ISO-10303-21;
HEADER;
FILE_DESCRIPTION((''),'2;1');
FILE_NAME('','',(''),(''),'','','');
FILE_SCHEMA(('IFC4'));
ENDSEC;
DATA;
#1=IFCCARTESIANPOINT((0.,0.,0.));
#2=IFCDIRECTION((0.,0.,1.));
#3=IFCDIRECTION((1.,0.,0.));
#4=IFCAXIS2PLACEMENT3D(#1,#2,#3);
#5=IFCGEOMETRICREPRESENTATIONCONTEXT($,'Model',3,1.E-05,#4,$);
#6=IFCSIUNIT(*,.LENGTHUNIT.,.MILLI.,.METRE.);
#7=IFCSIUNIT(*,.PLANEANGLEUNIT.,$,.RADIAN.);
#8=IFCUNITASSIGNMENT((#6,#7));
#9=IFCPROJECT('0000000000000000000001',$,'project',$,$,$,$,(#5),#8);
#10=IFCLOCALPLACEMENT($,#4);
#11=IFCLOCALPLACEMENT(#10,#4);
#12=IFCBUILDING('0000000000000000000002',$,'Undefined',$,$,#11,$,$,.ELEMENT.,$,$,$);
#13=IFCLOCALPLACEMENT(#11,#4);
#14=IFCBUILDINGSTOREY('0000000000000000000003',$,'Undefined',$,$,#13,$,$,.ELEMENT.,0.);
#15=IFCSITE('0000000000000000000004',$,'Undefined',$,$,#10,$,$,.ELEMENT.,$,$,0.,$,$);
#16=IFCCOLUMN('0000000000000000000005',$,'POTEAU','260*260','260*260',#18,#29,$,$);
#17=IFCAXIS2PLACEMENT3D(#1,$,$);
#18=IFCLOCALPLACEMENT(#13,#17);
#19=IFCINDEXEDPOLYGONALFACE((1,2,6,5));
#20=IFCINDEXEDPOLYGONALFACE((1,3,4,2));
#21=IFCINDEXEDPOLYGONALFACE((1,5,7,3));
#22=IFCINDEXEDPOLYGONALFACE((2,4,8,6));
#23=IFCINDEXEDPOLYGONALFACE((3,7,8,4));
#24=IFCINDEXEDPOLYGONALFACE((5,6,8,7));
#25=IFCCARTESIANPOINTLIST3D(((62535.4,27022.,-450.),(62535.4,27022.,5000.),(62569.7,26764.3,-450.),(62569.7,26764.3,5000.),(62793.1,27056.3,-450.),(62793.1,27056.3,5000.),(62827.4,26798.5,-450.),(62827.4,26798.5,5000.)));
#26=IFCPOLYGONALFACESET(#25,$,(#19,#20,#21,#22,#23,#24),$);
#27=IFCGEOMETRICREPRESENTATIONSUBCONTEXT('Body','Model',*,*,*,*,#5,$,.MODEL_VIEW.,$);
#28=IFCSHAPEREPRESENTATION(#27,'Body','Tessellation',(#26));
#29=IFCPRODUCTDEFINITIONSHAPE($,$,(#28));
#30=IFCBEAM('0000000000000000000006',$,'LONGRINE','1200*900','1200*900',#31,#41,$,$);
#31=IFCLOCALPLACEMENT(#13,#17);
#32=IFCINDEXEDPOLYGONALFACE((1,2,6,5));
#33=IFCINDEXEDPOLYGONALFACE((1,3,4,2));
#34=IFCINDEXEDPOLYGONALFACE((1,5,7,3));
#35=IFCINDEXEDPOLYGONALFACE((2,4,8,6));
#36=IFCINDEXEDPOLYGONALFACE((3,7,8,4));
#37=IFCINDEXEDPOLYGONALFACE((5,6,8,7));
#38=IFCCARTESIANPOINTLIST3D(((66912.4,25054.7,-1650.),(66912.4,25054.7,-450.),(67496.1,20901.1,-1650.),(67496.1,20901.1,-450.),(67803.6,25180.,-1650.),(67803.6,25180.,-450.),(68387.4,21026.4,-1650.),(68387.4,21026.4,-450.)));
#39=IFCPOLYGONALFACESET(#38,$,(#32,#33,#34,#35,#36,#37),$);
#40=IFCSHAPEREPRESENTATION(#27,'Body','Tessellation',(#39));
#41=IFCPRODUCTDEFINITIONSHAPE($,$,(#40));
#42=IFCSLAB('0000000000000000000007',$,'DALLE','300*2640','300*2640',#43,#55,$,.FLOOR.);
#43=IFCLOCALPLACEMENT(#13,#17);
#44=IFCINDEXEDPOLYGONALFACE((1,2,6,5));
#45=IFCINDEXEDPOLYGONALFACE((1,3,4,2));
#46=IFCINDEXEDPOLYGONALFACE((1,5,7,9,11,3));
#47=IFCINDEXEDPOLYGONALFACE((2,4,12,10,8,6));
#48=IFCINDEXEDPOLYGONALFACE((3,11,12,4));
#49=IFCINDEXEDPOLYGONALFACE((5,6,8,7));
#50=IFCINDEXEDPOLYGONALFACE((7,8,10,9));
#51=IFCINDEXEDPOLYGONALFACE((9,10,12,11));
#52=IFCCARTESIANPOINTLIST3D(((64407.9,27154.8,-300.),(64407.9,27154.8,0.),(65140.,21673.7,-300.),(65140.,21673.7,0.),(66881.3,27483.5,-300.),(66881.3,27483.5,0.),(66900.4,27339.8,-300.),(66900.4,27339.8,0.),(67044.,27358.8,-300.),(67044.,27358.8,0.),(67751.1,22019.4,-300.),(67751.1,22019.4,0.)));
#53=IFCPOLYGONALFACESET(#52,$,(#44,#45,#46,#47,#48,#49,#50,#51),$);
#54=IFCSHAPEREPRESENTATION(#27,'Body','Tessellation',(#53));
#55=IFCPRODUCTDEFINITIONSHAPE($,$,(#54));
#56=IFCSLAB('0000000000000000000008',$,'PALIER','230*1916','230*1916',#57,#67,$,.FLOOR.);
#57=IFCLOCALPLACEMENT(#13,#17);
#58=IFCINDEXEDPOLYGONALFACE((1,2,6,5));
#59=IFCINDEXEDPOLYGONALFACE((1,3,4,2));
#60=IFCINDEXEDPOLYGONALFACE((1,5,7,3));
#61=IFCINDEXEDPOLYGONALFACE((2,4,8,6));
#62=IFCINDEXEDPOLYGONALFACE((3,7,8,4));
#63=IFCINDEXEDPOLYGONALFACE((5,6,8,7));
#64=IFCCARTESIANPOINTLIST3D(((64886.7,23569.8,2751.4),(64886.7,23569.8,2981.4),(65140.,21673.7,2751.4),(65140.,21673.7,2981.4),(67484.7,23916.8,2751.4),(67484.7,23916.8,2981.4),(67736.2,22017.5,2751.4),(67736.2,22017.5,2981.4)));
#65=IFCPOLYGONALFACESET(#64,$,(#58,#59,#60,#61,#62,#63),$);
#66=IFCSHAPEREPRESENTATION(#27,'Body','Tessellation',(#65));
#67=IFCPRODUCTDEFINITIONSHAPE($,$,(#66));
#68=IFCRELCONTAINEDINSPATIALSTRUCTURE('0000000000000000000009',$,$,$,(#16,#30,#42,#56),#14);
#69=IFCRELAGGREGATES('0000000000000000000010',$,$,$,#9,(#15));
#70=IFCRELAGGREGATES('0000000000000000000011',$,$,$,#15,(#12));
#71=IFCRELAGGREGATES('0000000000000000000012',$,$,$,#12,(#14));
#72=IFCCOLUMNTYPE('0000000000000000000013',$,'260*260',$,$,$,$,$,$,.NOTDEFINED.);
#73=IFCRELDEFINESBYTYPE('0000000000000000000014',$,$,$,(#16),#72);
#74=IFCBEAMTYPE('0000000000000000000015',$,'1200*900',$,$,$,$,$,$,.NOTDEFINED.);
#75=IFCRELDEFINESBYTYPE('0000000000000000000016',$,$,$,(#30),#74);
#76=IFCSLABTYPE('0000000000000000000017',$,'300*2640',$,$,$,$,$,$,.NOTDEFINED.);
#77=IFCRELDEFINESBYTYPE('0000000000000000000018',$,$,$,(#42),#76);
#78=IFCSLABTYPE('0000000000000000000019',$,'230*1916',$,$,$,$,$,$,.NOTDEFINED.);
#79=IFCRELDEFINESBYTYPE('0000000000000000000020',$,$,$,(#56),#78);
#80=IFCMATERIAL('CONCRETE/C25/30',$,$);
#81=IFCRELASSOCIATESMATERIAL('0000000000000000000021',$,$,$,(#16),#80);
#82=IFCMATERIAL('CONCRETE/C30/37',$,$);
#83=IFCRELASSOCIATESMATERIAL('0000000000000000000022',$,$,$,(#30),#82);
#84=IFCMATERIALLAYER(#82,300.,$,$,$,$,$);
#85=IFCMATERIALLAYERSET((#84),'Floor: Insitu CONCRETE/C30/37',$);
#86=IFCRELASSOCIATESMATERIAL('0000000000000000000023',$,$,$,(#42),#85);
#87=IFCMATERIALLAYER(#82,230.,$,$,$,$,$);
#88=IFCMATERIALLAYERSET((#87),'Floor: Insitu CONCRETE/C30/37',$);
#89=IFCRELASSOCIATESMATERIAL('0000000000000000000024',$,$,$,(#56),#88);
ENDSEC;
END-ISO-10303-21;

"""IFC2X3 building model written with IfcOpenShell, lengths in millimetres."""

from ifc_helpers import new_model, si_unit, frame, origin_with_axes, origin_2d_with_axis, place, context, subcontext, project, spatial, polyline, rectangle, outline, extrude, material, layer, layer_set, layer_usage, type_object, element, save


model = new_model("IFC2X3")

# Units and contexts
model_context = context("Model", 3, precision=1e-05, world=origin_with_axes())
body_context = subcontext(model_context, "Body", "Model", "MODEL_VIEW")
ifc_project = project(units=[si_unit("LENGTHUNIT", "METRE", prefix="MILLI"), si_unit("PLANEANGLEUNIT", "RADIAN")], contexts=[model_context])

# Site, building, storey
site_placement = place(None, origin_with_axes())
site = spatial("IfcSite", under=ifc_project, at=site_placement, Name="Undefined", CompositionType="ELEMENT", RefElevation=0.0)
building_placement = place(site_placement, origin_with_axes())
building = spatial("IfcBuilding", under=site, at=building_placement, Name="Undefined", CompositionType="ELEMENT")
storey_placement = place(building_placement, origin_with_axes())
storey = spatial("IfcBuildingStorey", under=building, at=storey_placement, Name="Undefined", CompositionType="ELEMENT", Elevation=0.0)

# Column
ifc_material_1 = material(Name="CONCRETE/C30/37")
ifc_material_2 = material(Name="CONCRETE/C25/30")
column_type_1 = type_object("IfcColumnType", Name="260*260", PredefinedType="NOTDEFINED")
column_1_placement = place(storey_placement, frame((62681.4, 26910.3, -450.0), z_axis=(0.0, 0.0, 1.0), x_axis=(1.0, 0.0, 0.0)))
element("IfcColumn", 1, at=column_1_placement, inside=storey, type_object=column_type_1, material=ifc_material_2, Name="POTEAU", Description="260*260", ObjectType="260*260", context=body_context, shape_type="SweptSolid", body=[
    extrude(rectangle(XDim=260.0, YDim=260.0, at=origin_2d_with_axis()), frame((0.0, 0.0, 5450.0), z_axis=(0.0, 0.0, -1.0), x_axis=(-0.131727, 0.991286, 0.0)), (0.0, 0.0, 1.0), 5450.0),
])

# Beam
beam_type_1 = type_object("IfcBeamType", Name="1200*900", PredefinedType="NOTDEFINED")
beam_1_placement = place(storey_placement, frame((67941.7, 20963.8, -1050.0), z_axis=(0.0, 0.0, 1.0), x_axis=(-0.139174, 0.990268, 0.0)))
element("IfcBeam", 2, at=beam_1_placement, inside=storey, type_object=beam_type_1, material=ifc_material_1, Name="LONGRINE", Description="1200*900", ObjectType="1200*900", context=body_context, shape_type="SweptSolid", body=[
    extrude(rectangle(XDim=900.0, YDim=1200.0, at=origin_2d_with_axis()), frame((4194.4, 0.0, 0.0), z_axis=(-1.0, 0.0, 0.0), x_axis=(0.0, -1.0, 0.0)), (0.0, 0.0, 1.0), 4194.4),
])

# Slabs
ifc_layer_1 = layer(ifc_material_1, 300.0)
ifc_layer_set_1 = layer_set([ifc_layer_1], Name="Floor: Insitu CONCRETE/C30/37")
ifc_layer_usage_1 = layer_usage(ifc_layer_set_1, "AXIS3", "POSITIVE", -150.0)
slab_type_1 = type_object("IfcSlabType", Name="300*2640", PredefinedType="NOTDEFINED")
slab_1_placement = place(storey_placement, frame((67751.1, 22019.4, -150.0), z_axis=(0.0, 0.0, -1.0), x_axis=(-0.991345, -0.131283, 0.0)))
element("IfcSlab", 3, at=slab_1_placement, inside=storey, type_object=slab_type_1, material=ifc_layer_usage_1, Name="DALLE", Description="300*2640", ObjectType="300*2640", PredefinedType="FLOOR", context=body_context, shape_type="SweptSolid", body=[
    extrude(outline(polyline([(0.0, 0.0), (2633.9, 0.0), (2640.1, 5529.8), (144.9, 5531.0), (144.9, 5386.0), (0.0, 5386.0), (0.0, 0.0)])), frame((0.0, 0.0, -150.0), z_axis=(0.0, 0.0, 1.0), x_axis=(1.0, 0.0, 0.0)), (0.0, 0.0, 1.0), 300.0),
])
ifc_layer_2 = layer(ifc_material_1, 230.0)
ifc_layer_set_2 = layer_set([ifc_layer_2], Name="Floor: Insitu CONCRETE/C30/37")
ifc_layer_usage_2 = layer_usage(ifc_layer_set_2, "AXIS3", "POSITIVE", -115.0)
slab_type_2 = type_object("IfcSlabType", Name="230*1916", PredefinedType="NOTDEFINED")
slab_2_placement = place(storey_placement, frame((65140.0, 21673.7, 2866.4), z_axis=(0.0, 0.0, 1.0), x_axis=(0.991345, 0.131283, 0.0)))
element("IfcSlab", 4, at=slab_2_placement, inside=storey, type_object=slab_type_2, material=ifc_layer_usage_2, Name="PALIER", Description="230*1916", ObjectType="230*1916", PredefinedType="FLOOR", context=body_context, shape_type="SweptSolid", body=[
    extrude(outline(polyline([(0.0, 0.0), (2618.9, 0.0), (2618.9, 1916.0), (-2.1, 1913.0), (0.0, 0.0)])), frame((0.0, 0.0, -115.0), z_axis=(0.0, 0.0, 1.0), x_axis=(1.0, 0.0, 0.0)), (0.0, 0.0, 1.0), 230.0),
])

save(model, "model.ifc")
